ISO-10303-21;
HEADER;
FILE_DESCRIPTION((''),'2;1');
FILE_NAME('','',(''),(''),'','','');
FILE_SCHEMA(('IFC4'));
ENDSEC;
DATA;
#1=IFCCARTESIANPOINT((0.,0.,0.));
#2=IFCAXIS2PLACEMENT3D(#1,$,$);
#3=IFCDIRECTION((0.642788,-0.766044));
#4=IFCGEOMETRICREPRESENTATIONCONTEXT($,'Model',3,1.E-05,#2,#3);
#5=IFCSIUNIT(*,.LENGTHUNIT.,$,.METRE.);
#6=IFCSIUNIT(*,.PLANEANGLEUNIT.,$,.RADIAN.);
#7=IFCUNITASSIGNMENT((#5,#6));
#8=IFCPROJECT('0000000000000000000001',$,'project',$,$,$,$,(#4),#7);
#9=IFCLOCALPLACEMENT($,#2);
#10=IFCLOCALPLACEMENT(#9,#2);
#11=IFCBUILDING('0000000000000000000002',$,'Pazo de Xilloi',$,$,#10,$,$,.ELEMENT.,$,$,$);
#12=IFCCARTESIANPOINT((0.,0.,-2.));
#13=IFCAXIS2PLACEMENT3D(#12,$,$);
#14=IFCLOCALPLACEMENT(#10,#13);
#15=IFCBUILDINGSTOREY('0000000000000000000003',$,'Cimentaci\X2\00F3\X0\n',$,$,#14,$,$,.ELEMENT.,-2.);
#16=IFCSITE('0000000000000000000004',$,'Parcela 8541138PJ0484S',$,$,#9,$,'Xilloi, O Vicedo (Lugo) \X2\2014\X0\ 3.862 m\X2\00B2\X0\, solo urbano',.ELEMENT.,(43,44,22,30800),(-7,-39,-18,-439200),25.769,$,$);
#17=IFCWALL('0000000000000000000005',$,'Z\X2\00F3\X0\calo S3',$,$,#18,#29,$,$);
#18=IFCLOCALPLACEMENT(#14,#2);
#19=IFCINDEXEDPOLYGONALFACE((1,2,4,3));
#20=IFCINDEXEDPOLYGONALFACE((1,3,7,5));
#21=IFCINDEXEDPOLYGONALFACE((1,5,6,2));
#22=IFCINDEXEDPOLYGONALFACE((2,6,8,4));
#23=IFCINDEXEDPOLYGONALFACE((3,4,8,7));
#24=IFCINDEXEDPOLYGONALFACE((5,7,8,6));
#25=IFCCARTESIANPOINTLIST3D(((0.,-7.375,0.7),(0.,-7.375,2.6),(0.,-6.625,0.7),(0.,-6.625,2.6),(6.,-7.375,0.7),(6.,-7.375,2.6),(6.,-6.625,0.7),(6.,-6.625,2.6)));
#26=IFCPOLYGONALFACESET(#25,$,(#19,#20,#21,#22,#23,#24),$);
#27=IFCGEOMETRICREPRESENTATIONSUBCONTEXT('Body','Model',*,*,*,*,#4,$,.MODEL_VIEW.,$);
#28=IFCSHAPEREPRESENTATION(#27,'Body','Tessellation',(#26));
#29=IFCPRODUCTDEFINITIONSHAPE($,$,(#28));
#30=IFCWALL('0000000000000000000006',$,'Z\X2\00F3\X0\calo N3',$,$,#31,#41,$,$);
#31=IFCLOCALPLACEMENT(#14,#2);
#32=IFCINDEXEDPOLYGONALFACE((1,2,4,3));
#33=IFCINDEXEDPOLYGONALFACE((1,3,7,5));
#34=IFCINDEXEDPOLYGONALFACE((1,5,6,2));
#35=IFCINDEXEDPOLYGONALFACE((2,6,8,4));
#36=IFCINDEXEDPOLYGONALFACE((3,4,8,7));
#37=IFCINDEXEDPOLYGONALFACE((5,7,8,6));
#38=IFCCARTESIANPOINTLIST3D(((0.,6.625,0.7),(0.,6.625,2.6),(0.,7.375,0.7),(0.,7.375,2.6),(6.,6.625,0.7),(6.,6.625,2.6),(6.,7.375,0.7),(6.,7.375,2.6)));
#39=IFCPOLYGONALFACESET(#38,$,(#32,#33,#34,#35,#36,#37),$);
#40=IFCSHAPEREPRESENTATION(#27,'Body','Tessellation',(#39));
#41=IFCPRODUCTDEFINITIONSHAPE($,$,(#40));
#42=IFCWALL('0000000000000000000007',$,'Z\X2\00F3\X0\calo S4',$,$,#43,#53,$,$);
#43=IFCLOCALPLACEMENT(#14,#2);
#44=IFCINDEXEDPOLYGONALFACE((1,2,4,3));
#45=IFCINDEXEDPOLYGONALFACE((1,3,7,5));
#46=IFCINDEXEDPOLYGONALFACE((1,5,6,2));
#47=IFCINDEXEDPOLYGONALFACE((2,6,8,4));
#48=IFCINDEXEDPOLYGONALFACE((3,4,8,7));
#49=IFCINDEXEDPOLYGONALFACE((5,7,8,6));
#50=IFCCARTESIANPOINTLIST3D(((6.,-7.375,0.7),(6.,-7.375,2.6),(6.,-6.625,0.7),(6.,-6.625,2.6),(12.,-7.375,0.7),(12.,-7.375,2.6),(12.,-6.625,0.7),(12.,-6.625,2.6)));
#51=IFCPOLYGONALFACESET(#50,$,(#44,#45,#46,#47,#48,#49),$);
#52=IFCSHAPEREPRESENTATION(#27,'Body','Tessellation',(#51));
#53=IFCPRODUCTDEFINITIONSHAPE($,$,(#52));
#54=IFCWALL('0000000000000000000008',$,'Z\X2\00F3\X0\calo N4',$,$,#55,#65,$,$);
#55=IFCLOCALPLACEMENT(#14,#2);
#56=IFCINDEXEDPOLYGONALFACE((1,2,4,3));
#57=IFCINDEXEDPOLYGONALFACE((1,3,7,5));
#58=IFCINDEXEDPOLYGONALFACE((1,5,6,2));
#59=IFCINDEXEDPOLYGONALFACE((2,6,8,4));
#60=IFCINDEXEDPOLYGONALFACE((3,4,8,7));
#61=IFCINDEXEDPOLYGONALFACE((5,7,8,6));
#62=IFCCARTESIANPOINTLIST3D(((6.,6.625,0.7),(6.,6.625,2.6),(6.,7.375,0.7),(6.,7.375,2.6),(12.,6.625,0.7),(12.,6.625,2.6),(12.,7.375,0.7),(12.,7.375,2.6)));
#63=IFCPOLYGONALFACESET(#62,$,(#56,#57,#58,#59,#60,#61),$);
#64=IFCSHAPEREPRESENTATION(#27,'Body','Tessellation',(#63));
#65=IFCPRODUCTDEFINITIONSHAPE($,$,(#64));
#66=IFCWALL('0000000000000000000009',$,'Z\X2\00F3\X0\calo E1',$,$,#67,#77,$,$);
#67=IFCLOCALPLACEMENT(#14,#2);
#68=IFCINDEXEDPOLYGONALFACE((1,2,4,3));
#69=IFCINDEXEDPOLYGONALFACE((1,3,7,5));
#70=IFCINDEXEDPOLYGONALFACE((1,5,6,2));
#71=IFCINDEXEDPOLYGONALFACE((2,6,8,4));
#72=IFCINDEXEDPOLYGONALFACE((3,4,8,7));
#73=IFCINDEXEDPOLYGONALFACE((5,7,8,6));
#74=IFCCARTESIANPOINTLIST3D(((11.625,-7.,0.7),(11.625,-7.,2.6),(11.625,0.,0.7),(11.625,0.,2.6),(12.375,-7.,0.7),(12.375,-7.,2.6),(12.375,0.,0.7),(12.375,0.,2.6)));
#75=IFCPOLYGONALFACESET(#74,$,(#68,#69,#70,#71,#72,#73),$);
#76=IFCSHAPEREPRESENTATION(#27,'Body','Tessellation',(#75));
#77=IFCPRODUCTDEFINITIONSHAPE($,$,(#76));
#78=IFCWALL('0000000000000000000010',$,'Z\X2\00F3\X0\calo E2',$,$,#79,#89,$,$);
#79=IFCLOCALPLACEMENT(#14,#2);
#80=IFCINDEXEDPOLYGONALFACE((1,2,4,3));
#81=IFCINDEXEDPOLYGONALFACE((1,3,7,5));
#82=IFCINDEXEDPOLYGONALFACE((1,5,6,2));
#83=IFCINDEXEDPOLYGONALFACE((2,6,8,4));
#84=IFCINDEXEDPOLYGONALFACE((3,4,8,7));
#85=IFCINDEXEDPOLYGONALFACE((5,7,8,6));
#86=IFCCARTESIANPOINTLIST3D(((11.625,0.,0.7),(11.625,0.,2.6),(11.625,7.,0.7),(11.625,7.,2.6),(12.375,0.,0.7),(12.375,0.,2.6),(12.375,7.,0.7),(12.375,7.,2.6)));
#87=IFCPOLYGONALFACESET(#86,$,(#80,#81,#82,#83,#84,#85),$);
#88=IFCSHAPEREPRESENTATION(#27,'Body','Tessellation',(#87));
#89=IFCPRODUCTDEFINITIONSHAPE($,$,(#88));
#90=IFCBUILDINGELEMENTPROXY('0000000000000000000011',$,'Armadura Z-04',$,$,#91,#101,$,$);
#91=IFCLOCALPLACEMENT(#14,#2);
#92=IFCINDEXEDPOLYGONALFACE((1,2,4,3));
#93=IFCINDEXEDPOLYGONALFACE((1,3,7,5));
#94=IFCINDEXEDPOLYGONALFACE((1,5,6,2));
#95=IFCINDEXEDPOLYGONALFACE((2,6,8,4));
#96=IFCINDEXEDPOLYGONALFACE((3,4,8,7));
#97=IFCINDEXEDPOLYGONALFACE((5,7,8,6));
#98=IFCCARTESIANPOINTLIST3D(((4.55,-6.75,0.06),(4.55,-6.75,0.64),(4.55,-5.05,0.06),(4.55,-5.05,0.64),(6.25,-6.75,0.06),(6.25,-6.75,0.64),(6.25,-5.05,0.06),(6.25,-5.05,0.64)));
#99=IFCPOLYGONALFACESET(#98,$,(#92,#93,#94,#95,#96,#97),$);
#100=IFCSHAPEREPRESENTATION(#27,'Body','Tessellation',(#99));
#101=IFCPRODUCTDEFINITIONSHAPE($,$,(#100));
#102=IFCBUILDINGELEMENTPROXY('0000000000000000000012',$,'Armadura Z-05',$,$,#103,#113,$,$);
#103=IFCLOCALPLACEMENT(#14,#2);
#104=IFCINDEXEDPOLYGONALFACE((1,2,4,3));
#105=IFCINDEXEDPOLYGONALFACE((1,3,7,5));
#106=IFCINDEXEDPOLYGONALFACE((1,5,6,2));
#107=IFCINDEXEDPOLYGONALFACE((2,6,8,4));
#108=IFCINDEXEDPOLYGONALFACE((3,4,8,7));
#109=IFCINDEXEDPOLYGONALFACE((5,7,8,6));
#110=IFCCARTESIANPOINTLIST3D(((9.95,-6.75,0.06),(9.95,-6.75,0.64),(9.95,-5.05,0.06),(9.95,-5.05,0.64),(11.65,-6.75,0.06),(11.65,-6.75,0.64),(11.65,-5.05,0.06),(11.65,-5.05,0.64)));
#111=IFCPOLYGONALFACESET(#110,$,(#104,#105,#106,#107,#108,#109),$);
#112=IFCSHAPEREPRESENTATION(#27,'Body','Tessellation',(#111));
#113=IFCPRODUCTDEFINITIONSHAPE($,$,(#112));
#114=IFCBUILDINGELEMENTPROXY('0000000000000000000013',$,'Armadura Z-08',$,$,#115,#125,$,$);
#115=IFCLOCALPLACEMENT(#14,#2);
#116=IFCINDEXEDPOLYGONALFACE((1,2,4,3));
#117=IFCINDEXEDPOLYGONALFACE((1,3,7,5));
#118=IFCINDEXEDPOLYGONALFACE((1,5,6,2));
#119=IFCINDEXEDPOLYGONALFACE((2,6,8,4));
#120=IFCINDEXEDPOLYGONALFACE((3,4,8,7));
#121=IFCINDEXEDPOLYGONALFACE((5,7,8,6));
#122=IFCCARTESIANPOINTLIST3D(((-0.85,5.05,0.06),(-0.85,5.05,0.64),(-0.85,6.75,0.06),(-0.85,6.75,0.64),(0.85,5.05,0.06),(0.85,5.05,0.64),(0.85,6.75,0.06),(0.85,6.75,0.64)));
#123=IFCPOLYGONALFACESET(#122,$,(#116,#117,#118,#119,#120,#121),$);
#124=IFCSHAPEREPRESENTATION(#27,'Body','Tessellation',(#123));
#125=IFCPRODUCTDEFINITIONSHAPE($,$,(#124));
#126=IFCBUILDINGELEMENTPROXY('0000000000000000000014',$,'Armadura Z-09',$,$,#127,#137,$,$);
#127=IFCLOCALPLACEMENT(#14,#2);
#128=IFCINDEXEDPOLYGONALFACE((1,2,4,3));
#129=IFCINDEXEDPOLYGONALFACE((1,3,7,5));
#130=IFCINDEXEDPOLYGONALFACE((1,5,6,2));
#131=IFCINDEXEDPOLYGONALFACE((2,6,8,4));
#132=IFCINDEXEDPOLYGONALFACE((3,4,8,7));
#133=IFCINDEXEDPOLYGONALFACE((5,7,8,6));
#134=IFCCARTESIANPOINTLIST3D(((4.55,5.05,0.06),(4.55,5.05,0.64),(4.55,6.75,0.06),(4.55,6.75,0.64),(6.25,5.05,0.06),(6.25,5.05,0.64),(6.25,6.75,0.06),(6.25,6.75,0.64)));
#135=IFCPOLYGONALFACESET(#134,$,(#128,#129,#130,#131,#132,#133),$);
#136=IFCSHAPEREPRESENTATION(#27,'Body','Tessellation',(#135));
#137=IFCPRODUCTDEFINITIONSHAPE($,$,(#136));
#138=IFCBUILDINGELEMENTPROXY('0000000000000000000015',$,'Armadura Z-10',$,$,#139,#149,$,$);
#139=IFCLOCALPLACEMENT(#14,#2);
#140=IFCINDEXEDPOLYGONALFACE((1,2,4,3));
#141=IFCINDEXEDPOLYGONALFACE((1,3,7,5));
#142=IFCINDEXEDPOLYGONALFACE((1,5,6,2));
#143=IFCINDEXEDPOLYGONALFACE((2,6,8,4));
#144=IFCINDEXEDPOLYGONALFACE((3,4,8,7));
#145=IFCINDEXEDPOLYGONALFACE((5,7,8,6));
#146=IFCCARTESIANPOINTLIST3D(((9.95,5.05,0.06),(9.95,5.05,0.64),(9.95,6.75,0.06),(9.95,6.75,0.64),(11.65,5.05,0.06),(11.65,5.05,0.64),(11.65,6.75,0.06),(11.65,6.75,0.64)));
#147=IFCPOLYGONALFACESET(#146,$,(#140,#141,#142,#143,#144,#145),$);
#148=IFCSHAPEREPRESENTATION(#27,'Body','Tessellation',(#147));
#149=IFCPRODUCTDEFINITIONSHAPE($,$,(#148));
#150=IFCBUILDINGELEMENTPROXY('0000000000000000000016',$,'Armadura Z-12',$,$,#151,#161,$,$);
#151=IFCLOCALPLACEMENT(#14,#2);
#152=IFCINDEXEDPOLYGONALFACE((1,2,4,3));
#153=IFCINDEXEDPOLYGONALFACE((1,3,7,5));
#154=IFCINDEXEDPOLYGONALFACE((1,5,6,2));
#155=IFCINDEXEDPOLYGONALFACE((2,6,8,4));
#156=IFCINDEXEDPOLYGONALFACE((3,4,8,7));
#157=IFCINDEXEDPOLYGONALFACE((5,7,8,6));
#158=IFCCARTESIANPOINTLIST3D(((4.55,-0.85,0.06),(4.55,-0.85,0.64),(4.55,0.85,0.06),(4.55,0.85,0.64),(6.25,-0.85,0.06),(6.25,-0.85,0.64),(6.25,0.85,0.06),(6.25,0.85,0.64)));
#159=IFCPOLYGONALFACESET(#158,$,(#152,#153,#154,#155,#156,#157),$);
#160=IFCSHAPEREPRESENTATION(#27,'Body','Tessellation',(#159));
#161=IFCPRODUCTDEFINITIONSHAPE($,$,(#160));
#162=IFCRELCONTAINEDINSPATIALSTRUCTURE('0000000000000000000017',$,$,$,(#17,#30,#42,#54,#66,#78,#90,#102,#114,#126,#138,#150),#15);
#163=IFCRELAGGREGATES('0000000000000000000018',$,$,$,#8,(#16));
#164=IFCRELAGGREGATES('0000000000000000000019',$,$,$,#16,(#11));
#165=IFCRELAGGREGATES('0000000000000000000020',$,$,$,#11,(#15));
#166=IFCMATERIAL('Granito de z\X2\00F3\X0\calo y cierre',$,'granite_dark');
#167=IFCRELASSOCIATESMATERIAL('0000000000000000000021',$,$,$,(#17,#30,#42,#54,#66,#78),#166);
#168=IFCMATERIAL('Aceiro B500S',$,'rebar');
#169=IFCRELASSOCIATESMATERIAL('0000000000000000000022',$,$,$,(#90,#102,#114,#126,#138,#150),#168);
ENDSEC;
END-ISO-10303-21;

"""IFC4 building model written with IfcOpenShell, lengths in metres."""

from ifc_helpers import new_model, si_unit, direction, frame, origin, origin_2d, place, context, subcontext, project, spatial, rectangle, extrude, material, element, save


model = new_model("IFC4")

# Units and contexts
model_context = context("Model", 3, precision=1e-05, world=origin(), true_north=direction((0.642788, -0.766044)))
body_context = subcontext(model_context, "Body", "Model", "MODEL_VIEW")
ifc_project = project(units=[si_unit("LENGTHUNIT", "METRE"), si_unit("PLANEANGLEUNIT", "RADIAN")], contexts=[model_context])

# Site, building, storey
site_placement = place(None, origin())
site = spatial("IfcSite", under=ifc_project, at=site_placement, Name="Parcela 8541138PJ0484S", LongName="Xilloi, O Vicedo (Lugo) — 3.862 m², solo urbano", CompositionType="ELEMENT", RefLatitude=(43, 44, 22, 30800), RefLongitude=(-7, -39, -18, -439200), RefElevation=25.769)
building_placement = place(site_placement, origin())
building = spatial("IfcBuilding", under=site, at=building_placement, Name="Pazo de Xilloi", CompositionType="ELEMENT")
storey_placement = place(building_placement, frame((0.0, 0.0, -2.0)))
storey = spatial("IfcBuildingStorey", under=building, at=storey_placement, Name="Cimentación", CompositionType="ELEMENT", Elevation=-2.0)

# Walls
ifc_material_1 = material(Name="Granito de zócalo y cierre", Category="granite_dark")
for number, where, name in (
    (1, (3.0, -7.0, 1.65), "Zócalo S3"),
    (2, (3.0, 7.0, 1.65), "Zócalo N3"),
    (3, (9.0, -7.0, 1.65), "Zócalo S4"),
    (4, (9.0, 7.0, 1.65), "Zócalo N4"),
):
    element("IfcWall", number, at=place(storey_placement, frame(where)), inside=storey, material=ifc_material_1, Name=name, context=body_context, shape_type="SweptSolid", body=[
        extrude(rectangle(XDim=6.0, YDim=0.75, at=origin_2d()), frame((0.0, 0.0, -0.95)), (0.0, 0.0, 1.0), 1.9),
    ])
for number, where, name in (
    (5, (12.0, -3.5, 1.65), "Zócalo E1"),
    (6, (12.0, 3.5, 1.65), "Zócalo E2"),
):
    element("IfcWall", number, at=place(storey_placement, frame(where)), inside=storey, material=ifc_material_1, Name=name, context=body_context, shape_type="SweptSolid", body=[
        extrude(rectangle(XDim=0.75, YDim=7.0, at=origin_2d()), frame((0.0, 0.0, -0.95)), (0.0, 0.0, 1.0), 1.9),
    ])

# Building element proxies
ifc_material_2 = material(Name="Aceiro B500S", Category="rebar")
for number, where, name in (
    (7, (5.4, -5.9, 0.35), "Armadura Z-04"),
    (8, (10.8, -5.9, 0.35), "Armadura Z-05"),
    (9, (0.0, 5.9, 0.35), "Armadura Z-08"),
    (10, (5.4, 5.9, 0.35), "Armadura Z-09"),
    (11, (10.8, 5.9, 0.35), "Armadura Z-10"),
    (12, (5.4, 0.0, 0.35), "Armadura Z-12"),
):
    element("IfcBuildingElementProxy", number, at=place(storey_placement, frame(where)), inside=storey, material=ifc_material_2, Name=name, context=body_context, shape_type="SweptSolid", body=[
        extrude(rectangle(XDim=1.7, YDim=1.7, at=origin_2d()), frame((0.0, 0.0, -0.29)), (0.0, 0.0, 1.0), 0.58),
    ])

save(model, "model.ifc")
